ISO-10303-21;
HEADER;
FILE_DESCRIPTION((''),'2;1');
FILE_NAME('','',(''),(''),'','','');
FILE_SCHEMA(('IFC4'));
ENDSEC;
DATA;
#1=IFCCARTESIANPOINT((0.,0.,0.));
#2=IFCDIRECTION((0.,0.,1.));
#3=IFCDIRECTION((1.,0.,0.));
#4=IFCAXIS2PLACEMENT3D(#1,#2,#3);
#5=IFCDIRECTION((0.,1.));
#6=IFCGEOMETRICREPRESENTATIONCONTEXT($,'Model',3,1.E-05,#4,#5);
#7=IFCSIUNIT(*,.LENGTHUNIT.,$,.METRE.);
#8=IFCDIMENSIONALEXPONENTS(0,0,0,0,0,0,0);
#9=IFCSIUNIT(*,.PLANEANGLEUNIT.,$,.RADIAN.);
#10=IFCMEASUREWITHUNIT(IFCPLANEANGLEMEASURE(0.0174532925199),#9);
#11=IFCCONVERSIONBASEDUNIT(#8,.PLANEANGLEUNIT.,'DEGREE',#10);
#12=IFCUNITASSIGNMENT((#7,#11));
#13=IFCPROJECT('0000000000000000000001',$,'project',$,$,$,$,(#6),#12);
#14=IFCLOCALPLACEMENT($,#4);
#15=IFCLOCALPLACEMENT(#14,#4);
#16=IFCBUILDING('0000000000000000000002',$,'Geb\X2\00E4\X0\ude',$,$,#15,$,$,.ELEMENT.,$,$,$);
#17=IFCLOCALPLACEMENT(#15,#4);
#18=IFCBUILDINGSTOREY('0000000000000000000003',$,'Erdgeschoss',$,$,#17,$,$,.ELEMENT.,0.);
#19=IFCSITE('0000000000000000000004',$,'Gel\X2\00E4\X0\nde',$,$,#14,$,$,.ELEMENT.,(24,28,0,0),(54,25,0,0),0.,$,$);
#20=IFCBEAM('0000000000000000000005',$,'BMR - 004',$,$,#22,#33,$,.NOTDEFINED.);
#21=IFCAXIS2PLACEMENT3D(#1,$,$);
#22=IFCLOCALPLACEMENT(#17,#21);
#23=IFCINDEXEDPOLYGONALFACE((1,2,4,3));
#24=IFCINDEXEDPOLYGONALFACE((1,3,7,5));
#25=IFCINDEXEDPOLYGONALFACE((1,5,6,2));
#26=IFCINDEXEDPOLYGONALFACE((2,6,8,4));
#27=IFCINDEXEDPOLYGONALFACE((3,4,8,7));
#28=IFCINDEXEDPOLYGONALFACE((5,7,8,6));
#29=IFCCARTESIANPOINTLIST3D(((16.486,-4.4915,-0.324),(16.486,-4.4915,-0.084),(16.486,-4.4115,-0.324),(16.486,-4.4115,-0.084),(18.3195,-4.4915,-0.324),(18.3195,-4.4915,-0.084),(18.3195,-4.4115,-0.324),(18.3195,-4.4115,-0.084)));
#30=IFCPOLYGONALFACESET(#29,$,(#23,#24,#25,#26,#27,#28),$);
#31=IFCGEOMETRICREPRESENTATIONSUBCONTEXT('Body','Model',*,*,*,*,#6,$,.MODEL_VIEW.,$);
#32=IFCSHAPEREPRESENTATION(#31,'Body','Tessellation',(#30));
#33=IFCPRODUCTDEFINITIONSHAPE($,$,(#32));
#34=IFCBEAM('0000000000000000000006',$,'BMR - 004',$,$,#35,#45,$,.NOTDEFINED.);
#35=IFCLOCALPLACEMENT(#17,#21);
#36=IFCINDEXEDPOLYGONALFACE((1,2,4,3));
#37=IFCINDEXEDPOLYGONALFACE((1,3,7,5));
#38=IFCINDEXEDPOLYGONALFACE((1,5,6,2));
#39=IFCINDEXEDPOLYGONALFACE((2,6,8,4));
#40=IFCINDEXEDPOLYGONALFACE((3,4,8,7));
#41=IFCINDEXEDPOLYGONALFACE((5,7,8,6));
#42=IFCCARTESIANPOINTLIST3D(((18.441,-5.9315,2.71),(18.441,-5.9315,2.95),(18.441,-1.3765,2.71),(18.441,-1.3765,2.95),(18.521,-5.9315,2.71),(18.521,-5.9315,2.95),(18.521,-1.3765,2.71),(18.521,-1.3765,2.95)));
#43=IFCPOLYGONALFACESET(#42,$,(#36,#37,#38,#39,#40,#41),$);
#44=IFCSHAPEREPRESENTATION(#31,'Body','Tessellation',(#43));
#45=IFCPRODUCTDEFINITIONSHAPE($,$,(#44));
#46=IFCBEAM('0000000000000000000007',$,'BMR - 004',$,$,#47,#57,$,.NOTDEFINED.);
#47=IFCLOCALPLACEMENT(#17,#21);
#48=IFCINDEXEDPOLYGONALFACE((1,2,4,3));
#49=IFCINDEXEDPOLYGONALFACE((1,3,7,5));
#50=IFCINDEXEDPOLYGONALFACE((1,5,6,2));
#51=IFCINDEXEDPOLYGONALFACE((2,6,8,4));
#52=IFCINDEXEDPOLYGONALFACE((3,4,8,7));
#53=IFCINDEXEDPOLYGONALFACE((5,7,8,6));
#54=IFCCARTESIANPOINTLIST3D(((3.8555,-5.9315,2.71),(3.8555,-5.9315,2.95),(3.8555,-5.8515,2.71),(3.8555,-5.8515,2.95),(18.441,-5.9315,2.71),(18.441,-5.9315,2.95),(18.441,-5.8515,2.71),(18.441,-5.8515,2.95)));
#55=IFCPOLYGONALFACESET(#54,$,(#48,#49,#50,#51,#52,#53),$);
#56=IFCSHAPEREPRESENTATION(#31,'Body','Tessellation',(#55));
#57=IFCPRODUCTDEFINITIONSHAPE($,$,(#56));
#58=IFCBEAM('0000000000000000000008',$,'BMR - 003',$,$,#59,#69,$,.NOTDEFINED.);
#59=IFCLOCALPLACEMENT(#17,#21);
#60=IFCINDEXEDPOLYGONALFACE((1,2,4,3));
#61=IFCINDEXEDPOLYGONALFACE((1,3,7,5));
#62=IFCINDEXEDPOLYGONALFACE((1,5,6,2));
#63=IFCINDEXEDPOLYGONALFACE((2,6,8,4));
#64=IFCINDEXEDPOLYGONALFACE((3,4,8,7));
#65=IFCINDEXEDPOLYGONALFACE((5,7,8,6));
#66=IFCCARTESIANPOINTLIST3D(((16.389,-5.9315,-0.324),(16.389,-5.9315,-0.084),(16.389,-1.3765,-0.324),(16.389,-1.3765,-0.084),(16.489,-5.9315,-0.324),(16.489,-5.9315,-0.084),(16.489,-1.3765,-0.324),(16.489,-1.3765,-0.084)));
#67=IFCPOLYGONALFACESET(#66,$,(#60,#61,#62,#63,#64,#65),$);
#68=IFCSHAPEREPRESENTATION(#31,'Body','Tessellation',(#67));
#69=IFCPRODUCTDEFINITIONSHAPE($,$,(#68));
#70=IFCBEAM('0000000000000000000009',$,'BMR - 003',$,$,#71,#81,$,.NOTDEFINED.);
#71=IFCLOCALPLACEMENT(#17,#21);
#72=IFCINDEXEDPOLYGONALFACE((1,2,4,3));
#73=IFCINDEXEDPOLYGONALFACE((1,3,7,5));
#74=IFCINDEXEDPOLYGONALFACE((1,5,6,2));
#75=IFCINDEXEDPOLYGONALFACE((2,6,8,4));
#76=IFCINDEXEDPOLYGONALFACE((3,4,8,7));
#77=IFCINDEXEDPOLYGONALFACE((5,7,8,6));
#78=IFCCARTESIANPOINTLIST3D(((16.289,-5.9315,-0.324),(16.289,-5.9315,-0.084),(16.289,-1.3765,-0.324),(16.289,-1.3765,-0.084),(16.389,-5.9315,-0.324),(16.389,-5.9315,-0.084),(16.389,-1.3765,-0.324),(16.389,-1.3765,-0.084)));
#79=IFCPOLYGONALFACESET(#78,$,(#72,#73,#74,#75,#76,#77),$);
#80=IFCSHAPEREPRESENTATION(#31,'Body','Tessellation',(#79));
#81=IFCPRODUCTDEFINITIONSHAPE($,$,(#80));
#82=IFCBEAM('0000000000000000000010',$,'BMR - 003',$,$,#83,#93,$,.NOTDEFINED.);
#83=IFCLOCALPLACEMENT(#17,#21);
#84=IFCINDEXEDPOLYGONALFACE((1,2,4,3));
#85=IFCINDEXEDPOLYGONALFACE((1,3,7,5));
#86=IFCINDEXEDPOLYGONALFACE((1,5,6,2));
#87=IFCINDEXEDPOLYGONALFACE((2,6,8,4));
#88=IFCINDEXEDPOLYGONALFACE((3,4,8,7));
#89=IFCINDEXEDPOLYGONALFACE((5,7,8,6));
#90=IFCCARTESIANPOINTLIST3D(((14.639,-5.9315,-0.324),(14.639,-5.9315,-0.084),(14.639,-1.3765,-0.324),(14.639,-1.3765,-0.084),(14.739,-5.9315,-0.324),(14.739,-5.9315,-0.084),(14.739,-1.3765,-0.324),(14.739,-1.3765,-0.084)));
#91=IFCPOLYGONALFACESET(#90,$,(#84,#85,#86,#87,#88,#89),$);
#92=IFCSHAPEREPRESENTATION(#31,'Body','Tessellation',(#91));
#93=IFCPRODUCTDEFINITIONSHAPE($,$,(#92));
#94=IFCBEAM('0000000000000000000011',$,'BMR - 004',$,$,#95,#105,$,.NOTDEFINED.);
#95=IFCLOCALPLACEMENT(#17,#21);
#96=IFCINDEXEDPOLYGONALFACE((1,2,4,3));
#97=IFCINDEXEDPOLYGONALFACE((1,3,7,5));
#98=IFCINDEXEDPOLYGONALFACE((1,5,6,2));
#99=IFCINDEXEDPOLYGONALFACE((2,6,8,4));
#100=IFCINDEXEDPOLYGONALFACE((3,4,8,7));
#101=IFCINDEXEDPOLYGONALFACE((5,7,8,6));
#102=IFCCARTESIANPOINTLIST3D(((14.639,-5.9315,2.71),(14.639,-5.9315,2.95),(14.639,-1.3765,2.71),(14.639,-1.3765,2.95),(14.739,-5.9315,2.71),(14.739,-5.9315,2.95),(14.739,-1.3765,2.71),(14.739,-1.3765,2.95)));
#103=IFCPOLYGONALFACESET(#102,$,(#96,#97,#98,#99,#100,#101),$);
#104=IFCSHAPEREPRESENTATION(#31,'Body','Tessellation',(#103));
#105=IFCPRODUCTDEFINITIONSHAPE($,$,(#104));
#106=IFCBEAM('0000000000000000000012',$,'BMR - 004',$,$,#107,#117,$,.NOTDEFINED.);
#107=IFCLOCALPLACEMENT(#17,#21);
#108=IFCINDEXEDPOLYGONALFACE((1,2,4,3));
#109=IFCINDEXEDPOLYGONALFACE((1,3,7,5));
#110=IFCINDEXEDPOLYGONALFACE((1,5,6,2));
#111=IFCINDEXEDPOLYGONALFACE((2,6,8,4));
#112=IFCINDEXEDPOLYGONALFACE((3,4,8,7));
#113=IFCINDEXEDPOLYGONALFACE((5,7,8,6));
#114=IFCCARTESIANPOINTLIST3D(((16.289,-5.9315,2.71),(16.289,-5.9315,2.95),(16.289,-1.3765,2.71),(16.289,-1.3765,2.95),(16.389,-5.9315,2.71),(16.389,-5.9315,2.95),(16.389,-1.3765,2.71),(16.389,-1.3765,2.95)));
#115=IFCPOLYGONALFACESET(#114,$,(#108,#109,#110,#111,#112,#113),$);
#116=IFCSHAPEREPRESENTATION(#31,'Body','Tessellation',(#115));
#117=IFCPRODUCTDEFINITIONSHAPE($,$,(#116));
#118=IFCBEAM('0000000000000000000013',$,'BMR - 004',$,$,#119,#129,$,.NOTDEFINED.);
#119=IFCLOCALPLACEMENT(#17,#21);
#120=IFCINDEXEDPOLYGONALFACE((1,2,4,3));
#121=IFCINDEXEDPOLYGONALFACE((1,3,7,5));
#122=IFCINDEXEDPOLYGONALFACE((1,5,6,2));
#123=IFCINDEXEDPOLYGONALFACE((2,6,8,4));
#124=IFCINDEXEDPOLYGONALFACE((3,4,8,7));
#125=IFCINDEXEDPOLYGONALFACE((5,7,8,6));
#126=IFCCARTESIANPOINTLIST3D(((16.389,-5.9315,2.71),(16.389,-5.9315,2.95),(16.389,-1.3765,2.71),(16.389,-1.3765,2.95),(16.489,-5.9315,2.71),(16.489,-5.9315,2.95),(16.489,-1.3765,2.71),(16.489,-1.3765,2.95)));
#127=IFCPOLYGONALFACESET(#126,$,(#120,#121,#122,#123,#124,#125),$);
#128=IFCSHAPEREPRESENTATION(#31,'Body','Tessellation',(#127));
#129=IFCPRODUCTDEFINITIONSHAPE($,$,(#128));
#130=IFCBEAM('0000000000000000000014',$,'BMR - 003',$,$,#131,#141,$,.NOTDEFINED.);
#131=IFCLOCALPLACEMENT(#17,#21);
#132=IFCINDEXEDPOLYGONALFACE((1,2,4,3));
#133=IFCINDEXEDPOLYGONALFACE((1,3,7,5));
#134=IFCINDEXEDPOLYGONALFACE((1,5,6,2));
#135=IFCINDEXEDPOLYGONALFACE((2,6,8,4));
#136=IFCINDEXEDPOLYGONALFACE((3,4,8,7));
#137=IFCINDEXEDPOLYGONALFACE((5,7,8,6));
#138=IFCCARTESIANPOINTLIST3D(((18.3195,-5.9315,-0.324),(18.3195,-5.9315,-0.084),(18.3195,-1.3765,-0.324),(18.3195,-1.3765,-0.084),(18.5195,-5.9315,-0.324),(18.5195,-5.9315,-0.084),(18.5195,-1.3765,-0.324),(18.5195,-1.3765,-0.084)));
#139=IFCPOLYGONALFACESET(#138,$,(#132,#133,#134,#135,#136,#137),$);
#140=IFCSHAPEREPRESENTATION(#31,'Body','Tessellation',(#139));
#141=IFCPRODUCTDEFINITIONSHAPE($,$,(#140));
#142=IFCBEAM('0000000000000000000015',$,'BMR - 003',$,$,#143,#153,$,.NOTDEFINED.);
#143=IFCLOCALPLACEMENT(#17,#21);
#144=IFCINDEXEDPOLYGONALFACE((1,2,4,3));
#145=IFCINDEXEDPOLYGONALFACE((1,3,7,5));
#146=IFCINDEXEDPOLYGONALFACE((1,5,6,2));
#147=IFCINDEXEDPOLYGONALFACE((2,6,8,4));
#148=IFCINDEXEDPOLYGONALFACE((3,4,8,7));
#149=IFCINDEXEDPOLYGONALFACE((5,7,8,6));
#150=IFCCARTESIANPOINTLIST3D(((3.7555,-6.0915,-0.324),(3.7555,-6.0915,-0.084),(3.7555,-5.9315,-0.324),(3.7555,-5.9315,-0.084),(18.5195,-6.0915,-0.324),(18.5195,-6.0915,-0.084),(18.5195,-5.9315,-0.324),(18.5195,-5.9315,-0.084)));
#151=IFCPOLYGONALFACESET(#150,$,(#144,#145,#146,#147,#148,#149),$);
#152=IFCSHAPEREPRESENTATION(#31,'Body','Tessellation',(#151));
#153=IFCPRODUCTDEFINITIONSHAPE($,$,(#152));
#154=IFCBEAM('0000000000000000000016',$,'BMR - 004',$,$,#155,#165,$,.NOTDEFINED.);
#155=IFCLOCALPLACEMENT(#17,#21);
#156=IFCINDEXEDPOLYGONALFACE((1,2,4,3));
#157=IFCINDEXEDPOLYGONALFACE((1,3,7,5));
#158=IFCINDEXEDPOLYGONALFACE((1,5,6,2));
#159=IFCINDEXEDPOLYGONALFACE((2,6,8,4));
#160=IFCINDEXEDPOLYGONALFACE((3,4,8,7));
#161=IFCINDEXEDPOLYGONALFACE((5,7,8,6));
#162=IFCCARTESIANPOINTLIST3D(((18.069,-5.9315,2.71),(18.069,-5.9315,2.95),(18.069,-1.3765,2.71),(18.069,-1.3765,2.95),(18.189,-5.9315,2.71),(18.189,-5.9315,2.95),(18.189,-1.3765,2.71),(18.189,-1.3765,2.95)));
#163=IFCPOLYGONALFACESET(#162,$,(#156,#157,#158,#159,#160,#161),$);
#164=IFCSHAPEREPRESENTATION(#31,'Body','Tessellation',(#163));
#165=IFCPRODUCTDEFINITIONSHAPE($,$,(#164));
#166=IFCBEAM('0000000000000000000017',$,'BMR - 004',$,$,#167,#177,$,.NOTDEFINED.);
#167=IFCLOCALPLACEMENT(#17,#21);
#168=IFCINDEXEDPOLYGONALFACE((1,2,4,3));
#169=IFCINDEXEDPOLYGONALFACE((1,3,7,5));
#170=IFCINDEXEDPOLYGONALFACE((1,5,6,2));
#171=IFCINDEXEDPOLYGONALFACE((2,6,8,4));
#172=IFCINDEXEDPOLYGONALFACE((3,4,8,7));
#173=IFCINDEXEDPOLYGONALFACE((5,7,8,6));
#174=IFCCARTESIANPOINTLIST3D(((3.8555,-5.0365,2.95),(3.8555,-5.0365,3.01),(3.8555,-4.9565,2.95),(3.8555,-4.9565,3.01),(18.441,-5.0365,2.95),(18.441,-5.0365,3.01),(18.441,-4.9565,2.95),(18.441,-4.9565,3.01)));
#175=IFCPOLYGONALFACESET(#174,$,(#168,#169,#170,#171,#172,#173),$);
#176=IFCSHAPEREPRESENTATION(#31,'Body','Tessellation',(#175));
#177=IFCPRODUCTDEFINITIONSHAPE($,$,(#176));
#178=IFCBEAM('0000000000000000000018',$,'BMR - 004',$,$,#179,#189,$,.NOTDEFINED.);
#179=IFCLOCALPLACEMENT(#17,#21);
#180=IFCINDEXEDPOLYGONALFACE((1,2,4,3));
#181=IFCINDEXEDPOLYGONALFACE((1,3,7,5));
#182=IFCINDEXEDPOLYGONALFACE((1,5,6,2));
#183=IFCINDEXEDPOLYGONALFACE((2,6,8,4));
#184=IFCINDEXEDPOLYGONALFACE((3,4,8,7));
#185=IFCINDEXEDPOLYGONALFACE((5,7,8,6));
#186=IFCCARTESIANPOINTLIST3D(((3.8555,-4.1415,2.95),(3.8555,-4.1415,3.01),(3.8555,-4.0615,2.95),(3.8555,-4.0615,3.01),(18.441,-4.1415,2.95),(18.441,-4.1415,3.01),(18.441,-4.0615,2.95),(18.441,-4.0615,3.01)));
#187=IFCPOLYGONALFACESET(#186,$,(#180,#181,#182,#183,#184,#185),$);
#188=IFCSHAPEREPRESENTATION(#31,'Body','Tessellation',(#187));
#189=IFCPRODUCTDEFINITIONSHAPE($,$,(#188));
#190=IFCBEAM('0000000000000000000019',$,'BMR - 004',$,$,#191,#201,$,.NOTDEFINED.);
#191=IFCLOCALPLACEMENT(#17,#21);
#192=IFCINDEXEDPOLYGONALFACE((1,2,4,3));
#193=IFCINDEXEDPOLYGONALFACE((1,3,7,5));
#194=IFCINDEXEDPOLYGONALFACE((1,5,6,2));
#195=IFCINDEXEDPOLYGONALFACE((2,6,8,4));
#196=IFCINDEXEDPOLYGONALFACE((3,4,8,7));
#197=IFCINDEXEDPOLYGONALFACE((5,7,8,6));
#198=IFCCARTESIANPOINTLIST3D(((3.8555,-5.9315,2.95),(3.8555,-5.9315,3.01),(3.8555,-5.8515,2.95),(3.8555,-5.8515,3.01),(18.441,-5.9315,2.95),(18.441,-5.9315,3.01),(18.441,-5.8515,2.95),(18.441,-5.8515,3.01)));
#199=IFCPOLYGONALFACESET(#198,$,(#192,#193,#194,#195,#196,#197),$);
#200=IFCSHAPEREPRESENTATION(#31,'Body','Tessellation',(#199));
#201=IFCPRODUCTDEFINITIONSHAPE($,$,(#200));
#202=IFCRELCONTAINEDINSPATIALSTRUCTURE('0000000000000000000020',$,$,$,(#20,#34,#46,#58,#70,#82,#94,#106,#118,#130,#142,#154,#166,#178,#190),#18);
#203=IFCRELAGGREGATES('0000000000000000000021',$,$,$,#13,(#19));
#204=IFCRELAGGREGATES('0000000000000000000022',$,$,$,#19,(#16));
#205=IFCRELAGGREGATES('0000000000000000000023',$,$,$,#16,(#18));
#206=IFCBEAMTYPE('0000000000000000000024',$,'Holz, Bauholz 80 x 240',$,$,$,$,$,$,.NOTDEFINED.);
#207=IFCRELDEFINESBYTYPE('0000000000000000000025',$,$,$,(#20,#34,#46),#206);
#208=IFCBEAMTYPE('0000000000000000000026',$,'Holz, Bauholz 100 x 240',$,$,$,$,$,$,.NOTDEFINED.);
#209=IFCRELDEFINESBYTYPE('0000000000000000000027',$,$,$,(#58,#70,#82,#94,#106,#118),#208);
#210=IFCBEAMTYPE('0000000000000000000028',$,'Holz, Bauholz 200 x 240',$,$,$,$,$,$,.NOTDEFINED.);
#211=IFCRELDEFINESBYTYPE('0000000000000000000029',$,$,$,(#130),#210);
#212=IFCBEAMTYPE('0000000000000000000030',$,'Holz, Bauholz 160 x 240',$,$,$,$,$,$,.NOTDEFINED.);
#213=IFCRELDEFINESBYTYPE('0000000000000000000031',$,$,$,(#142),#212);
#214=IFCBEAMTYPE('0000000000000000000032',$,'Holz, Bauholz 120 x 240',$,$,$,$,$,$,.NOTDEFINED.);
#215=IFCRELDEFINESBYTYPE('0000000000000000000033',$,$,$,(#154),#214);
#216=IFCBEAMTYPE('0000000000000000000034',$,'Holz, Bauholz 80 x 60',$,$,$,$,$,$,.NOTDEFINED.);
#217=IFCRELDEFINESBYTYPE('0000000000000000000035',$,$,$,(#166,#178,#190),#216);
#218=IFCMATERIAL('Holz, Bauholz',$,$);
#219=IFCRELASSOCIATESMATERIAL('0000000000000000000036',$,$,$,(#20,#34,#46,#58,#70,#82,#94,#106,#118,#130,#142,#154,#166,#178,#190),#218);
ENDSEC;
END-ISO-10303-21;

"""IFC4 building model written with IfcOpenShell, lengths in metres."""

from ifc_helpers import new_model, entity, si_unit, converted_unit, direction, frame, frame_2d, origin_with_axes, place, context, subcontext, project, spatial, rectangle, extrude, material, type_object, element, save


model = new_model("IFC4")

# Units and contexts
model_context = context("Model", 3, precision=1e-05, world=origin_with_axes(), true_north=direction((0.0, 1.0)))
body_context = subcontext(model_context, "Body", "Model", "MODEL_VIEW")
ifc_project = project(units=[si_unit("LENGTHUNIT", "METRE"), converted_unit("PLANEANGLEUNIT", "DEGREE", entity("IfcPlaneAngleMeasure", 0.0174532925199), si_unit("PLANEANGLEUNIT", "RADIAN"), dimensions=[0, 0, 0, 0, 0, 0, 0])], contexts=[model_context])

# Site, building, storey
site_placement = place(None, origin_with_axes())
site = spatial("IfcSite", under=ifc_project, at=site_placement, Name="Gelände", CompositionType="ELEMENT", RefLatitude=(24, 28, 0, 0), RefLongitude=(54, 25, 0, 0), RefElevation=0.0)
building_placement = place(site_placement, origin_with_axes())
building = spatial("IfcBuilding", under=site, at=building_placement, Name="Gebäude", CompositionType="ELEMENT")
storey_placement = place(building_placement, origin_with_axes())
storey = spatial("IfcBuildingStorey", under=building, at=storey_placement, Name="Erdgeschoss", CompositionType="ELEMENT", Elevation=0.0)

# Shared definitions
ifc_material_1 = material(Name="Holz, Bauholz")

# Beams
beam_type_1 = type_object("IfcBeamType", Name="Holz, Bauholz 80 x 240", PredefinedType="NOTDEFINED")
for number, where, z_axis, x_axis, name in (
    (1, (18.3195, -4.4515, -0.084), (0.0, 0.0, 1.0), (0.0, 1.0, 0.0), "BMR - 004"),
):
    element("IfcBeam", number, at=place(storey_placement, frame(where, z_axis=z_axis, x_axis=x_axis)), inside=storey, type_object=beam_type_1, material=ifc_material_1, Name=name, PredefinedType="NOTDEFINED", context=body_context, shape_type="SweptSolid", body=[
        extrude(rectangle(XDim=0.24, YDim=0.08, at=frame_2d((-0.12, 0.0), x_axis=(1.0, 0.0))), frame((0.0, 0.0, 0.0), z_axis=(0.0, 1.0, 0.0), x_axis=(0.0, 0.0, 1.0)), (0.0, 0.0, 1.0), 1.8335),
    ])
beam_1_placement = place(storey_placement, frame((18.481, -5.9315, 2.95), z_axis=(0.0, 0.0, 1.0), x_axis=(1.0, 0.0, 0.0)))
element("IfcBeam", 2, at=beam_1_placement, inside=storey, type_object=beam_type_1, material=ifc_material_1, Name="BMR - 004", PredefinedType="NOTDEFINED", context=body_context, shape_type="SweptSolid", body=[
    extrude(rectangle(XDim=0.24, YDim=0.08, at=frame_2d((-0.12, 0.0), x_axis=(1.0, 0.0))), frame((0.0, 0.0, 0.0), z_axis=(0.0, 1.0, 0.0), x_axis=(0.0, 0.0, 1.0)), (0.0, 0.0, 1.0), 4.555),
])
beam_2_placement = place(storey_placement, frame((18.441, -5.8915, 2.95), z_axis=(0.0, 0.0, 1.0), x_axis=(0.0, 1.0, 0.0)))
element("IfcBeam", 3, at=beam_2_placement, inside=storey, type_object=beam_type_1, material=ifc_material_1, Name="BMR - 004", PredefinedType="NOTDEFINED", context=body_context, shape_type="SweptSolid", body=[
    extrude(rectangle(XDim=0.24, YDim=0.08, at=frame_2d((-0.12, 0.0), x_axis=(1.0, 0.0))), frame((0.0, 0.0, 0.0), z_axis=(0.0, 1.0, 0.0), x_axis=(0.0, 0.0, 1.0)), (0.0, 0.0, 1.0), 14.5855),
])
beam_type_2 = type_object("IfcBeamType", Name="Holz, Bauholz 100 x 240", PredefinedType="NOTDEFINED")
beam_3_placement = place(storey_placement, frame((16.439, -5.9315, -0.084), z_axis=(0.0, 0.0, 1.0), x_axis=(1.0, 0.0, 0.0)))
element("IfcBeam", 4, at=beam_3_placement, inside=storey, type_object=beam_type_2, material=ifc_material_1, Name="BMR - 003", PredefinedType="NOTDEFINED", context=body_context, shape_type="SweptSolid", body=[
    extrude(rectangle(XDim=0.24, YDim=0.1, at=frame_2d((-0.12, 0.0), x_axis=(1.0, 0.0))), frame((0.0, 0.0, 0.0), z_axis=(0.0, 1.0, 0.0), x_axis=(0.0, 0.0, 1.0)), (0.0, 0.0, 1.0), 4.555),
])
beam_4_placement = place(storey_placement, frame((16.339, -5.9315, -0.084), z_axis=(0.0, 0.0, 1.0), x_axis=(1.0, 0.0, 0.0)))
element("IfcBeam", 5, at=beam_4_placement, inside=storey, type_object=beam_type_2, material=ifc_material_1, Name="BMR - 003", PredefinedType="NOTDEFINED", context=body_context, shape_type="SweptSolid", body=[
    extrude(rectangle(XDim=0.24, YDim=0.1, at=frame_2d((-0.12, 0.0), x_axis=(1.0, 0.0))), frame((0.0, 0.0, 0.0), z_axis=(0.0, 1.0, 0.0), x_axis=(0.0, 0.0, 1.0)), (0.0, 0.0, 1.0), 4.555),
])
beam_5_placement = place(storey_placement, frame((14.689, -5.9315, -0.084), z_axis=(0.0, 0.0, 1.0), x_axis=(1.0, 0.0, 0.0)))
element("IfcBeam", 6, at=beam_5_placement, inside=storey, type_object=beam_type_2, material=ifc_material_1, Name="BMR - 003", PredefinedType="NOTDEFINED", context=body_context, shape_type="SweptSolid", body=[
    extrude(rectangle(XDim=0.24, YDim=0.1, at=frame_2d((-0.12, 0.0), x_axis=(1.0, 0.0))), frame((0.0, 0.0, 0.0), z_axis=(0.0, 1.0, 0.0), x_axis=(0.0, 0.0, 1.0)), (0.0, 0.0, 1.0), 4.555),
])
for number, where, z_axis, x_axis, name in (
    (7, (14.689, -5.9315, 2.95), (0.0, 0.0, 1.0), (1.0, 0.0, 0.0), "BMR - 004"),
    (8, (16.339, -5.9315, 2.95), (0.0, 0.0, 1.0), (1.0, 0.0, 0.0), "BMR - 004"),
    (9, (16.439, -5.9315, 2.95), (0.0, 0.0, 1.0), (1.0, 0.0, 0.0), "BMR - 004"),
):
    element("IfcBeam", number, at=place(storey_placement, frame(where, z_axis=z_axis, x_axis=x_axis)), inside=storey, type_object=beam_type_2, material=ifc_material_1, Name=name, PredefinedType="NOTDEFINED", context=body_context, shape_type="SweptSolid", body=[
        extrude(rectangle(XDim=0.24, YDim=0.1, at=frame_2d((-0.12, 0.0), x_axis=(1.0, 0.0))), frame((0.0, 0.0, 0.0), z_axis=(0.0, 1.0, 0.0), x_axis=(0.0, 0.0, 1.0)), (0.0, 0.0, 1.0), 4.555),
    ])
beam_type_3 = type_object("IfcBeamType", Name="Holz, Bauholz 200 x 240", PredefinedType="NOTDEFINED")
beam_6_placement = place(storey_placement, frame((18.4195, -5.9315, -0.084), z_axis=(0.0, 0.0, 1.0), x_axis=(1.0, 0.0, 0.0)))
element("IfcBeam", 10, at=beam_6_placement, inside=storey, type_object=beam_type_3, material=ifc_material_1, Name="BMR - 003", PredefinedType="NOTDEFINED", context=body_context, shape_type="SweptSolid", body=[
    extrude(rectangle(XDim=0.24, YDim=0.2, at=frame_2d((-0.12, 0.0), x_axis=(1.0, 0.0))), frame((0.0, 0.0, 0.0), z_axis=(0.0, 1.0, 0.0), x_axis=(0.0, 0.0, 1.0)), (0.0, 0.0, 1.0), 4.555),
])
beam_type_4 = type_object("IfcBeamType", Name="Holz, Bauholz 160 x 240", PredefinedType="NOTDEFINED")
beam_7_placement = place(storey_placement, frame((18.5195, -6.0115, -0.084), z_axis=(0.0, 0.0, 1.0), x_axis=(0.0, 1.0, 0.0)))
element("IfcBeam", 11, at=beam_7_placement, inside=storey, type_object=beam_type_4, material=ifc_material_1, Name="BMR - 003", PredefinedType="NOTDEFINED", context=body_context, shape_type="SweptSolid", body=[
    extrude(rectangle(XDim=0.24, YDim=0.16, at=frame_2d((-0.12, 0.0), x_axis=(1.0, 0.0))), frame((0.0, 0.0, 0.0), z_axis=(0.0, 1.0, 0.0), x_axis=(0.0, 0.0, 1.0)), (0.0, 0.0, 1.0), 14.764),
])
beam_type_5 = type_object("IfcBeamType", Name="Holz, Bauholz 120 x 240", PredefinedType="NOTDEFINED")
beam_8_placement = place(storey_placement, frame((18.129, -5.9315, 2.95), z_axis=(0.0, 0.0, 1.0), x_axis=(1.0, 0.0, 0.0)))
element("IfcBeam", 12, at=beam_8_placement, inside=storey, type_object=beam_type_5, material=ifc_material_1, Name="BMR - 004", PredefinedType="NOTDEFINED", context=body_context, shape_type="SweptSolid", body=[
    extrude(rectangle(XDim=0.24, YDim=0.12, at=frame_2d((-0.12, 0.0), x_axis=(1.0, 0.0))), frame((0.0, 0.0, 0.0), z_axis=(0.0, 1.0, 0.0), x_axis=(0.0, 0.0, 1.0)), (0.0, 0.0, 1.0), 4.555),
])
beam_type_6 = type_object("IfcBeamType", Name="Holz, Bauholz 80 x 60", PredefinedType="NOTDEFINED")
for number, where, z_axis, x_axis, name in (
    (13, (18.441, -4.9965, 3.01), (0.0, 0.0, 1.0), (0.0, 1.0, 0.0), "BMR - 004"),
    (14, (18.441, -4.1015, 3.01), (0.0, 0.0, 1.0), (0.0, 1.0, 0.0), "BMR - 004"),
    (15, (18.441, -5.8915, 3.01), (0.0, 0.0, 1.0), (0.0, 1.0, 0.0), "BMR - 004"),
):
    element("IfcBeam", number, at=place(storey_placement, frame(where, z_axis=z_axis, x_axis=x_axis)), inside=storey, type_object=beam_type_6, material=ifc_material_1, Name=name, PredefinedType="NOTDEFINED", context=body_context, shape_type="SweptSolid", body=[
        extrude(rectangle(XDim=0.06, YDim=0.08, at=frame_2d((-0.03, 0.0), x_axis=(1.0, 0.0))), frame((0.0, 0.0, 0.0), z_axis=(0.0, 1.0, 0.0), x_axis=(0.0, 0.0, 1.0)), (0.0, 0.0, 1.0), 14.5855),
    ])

save(model, "model.ifc")
